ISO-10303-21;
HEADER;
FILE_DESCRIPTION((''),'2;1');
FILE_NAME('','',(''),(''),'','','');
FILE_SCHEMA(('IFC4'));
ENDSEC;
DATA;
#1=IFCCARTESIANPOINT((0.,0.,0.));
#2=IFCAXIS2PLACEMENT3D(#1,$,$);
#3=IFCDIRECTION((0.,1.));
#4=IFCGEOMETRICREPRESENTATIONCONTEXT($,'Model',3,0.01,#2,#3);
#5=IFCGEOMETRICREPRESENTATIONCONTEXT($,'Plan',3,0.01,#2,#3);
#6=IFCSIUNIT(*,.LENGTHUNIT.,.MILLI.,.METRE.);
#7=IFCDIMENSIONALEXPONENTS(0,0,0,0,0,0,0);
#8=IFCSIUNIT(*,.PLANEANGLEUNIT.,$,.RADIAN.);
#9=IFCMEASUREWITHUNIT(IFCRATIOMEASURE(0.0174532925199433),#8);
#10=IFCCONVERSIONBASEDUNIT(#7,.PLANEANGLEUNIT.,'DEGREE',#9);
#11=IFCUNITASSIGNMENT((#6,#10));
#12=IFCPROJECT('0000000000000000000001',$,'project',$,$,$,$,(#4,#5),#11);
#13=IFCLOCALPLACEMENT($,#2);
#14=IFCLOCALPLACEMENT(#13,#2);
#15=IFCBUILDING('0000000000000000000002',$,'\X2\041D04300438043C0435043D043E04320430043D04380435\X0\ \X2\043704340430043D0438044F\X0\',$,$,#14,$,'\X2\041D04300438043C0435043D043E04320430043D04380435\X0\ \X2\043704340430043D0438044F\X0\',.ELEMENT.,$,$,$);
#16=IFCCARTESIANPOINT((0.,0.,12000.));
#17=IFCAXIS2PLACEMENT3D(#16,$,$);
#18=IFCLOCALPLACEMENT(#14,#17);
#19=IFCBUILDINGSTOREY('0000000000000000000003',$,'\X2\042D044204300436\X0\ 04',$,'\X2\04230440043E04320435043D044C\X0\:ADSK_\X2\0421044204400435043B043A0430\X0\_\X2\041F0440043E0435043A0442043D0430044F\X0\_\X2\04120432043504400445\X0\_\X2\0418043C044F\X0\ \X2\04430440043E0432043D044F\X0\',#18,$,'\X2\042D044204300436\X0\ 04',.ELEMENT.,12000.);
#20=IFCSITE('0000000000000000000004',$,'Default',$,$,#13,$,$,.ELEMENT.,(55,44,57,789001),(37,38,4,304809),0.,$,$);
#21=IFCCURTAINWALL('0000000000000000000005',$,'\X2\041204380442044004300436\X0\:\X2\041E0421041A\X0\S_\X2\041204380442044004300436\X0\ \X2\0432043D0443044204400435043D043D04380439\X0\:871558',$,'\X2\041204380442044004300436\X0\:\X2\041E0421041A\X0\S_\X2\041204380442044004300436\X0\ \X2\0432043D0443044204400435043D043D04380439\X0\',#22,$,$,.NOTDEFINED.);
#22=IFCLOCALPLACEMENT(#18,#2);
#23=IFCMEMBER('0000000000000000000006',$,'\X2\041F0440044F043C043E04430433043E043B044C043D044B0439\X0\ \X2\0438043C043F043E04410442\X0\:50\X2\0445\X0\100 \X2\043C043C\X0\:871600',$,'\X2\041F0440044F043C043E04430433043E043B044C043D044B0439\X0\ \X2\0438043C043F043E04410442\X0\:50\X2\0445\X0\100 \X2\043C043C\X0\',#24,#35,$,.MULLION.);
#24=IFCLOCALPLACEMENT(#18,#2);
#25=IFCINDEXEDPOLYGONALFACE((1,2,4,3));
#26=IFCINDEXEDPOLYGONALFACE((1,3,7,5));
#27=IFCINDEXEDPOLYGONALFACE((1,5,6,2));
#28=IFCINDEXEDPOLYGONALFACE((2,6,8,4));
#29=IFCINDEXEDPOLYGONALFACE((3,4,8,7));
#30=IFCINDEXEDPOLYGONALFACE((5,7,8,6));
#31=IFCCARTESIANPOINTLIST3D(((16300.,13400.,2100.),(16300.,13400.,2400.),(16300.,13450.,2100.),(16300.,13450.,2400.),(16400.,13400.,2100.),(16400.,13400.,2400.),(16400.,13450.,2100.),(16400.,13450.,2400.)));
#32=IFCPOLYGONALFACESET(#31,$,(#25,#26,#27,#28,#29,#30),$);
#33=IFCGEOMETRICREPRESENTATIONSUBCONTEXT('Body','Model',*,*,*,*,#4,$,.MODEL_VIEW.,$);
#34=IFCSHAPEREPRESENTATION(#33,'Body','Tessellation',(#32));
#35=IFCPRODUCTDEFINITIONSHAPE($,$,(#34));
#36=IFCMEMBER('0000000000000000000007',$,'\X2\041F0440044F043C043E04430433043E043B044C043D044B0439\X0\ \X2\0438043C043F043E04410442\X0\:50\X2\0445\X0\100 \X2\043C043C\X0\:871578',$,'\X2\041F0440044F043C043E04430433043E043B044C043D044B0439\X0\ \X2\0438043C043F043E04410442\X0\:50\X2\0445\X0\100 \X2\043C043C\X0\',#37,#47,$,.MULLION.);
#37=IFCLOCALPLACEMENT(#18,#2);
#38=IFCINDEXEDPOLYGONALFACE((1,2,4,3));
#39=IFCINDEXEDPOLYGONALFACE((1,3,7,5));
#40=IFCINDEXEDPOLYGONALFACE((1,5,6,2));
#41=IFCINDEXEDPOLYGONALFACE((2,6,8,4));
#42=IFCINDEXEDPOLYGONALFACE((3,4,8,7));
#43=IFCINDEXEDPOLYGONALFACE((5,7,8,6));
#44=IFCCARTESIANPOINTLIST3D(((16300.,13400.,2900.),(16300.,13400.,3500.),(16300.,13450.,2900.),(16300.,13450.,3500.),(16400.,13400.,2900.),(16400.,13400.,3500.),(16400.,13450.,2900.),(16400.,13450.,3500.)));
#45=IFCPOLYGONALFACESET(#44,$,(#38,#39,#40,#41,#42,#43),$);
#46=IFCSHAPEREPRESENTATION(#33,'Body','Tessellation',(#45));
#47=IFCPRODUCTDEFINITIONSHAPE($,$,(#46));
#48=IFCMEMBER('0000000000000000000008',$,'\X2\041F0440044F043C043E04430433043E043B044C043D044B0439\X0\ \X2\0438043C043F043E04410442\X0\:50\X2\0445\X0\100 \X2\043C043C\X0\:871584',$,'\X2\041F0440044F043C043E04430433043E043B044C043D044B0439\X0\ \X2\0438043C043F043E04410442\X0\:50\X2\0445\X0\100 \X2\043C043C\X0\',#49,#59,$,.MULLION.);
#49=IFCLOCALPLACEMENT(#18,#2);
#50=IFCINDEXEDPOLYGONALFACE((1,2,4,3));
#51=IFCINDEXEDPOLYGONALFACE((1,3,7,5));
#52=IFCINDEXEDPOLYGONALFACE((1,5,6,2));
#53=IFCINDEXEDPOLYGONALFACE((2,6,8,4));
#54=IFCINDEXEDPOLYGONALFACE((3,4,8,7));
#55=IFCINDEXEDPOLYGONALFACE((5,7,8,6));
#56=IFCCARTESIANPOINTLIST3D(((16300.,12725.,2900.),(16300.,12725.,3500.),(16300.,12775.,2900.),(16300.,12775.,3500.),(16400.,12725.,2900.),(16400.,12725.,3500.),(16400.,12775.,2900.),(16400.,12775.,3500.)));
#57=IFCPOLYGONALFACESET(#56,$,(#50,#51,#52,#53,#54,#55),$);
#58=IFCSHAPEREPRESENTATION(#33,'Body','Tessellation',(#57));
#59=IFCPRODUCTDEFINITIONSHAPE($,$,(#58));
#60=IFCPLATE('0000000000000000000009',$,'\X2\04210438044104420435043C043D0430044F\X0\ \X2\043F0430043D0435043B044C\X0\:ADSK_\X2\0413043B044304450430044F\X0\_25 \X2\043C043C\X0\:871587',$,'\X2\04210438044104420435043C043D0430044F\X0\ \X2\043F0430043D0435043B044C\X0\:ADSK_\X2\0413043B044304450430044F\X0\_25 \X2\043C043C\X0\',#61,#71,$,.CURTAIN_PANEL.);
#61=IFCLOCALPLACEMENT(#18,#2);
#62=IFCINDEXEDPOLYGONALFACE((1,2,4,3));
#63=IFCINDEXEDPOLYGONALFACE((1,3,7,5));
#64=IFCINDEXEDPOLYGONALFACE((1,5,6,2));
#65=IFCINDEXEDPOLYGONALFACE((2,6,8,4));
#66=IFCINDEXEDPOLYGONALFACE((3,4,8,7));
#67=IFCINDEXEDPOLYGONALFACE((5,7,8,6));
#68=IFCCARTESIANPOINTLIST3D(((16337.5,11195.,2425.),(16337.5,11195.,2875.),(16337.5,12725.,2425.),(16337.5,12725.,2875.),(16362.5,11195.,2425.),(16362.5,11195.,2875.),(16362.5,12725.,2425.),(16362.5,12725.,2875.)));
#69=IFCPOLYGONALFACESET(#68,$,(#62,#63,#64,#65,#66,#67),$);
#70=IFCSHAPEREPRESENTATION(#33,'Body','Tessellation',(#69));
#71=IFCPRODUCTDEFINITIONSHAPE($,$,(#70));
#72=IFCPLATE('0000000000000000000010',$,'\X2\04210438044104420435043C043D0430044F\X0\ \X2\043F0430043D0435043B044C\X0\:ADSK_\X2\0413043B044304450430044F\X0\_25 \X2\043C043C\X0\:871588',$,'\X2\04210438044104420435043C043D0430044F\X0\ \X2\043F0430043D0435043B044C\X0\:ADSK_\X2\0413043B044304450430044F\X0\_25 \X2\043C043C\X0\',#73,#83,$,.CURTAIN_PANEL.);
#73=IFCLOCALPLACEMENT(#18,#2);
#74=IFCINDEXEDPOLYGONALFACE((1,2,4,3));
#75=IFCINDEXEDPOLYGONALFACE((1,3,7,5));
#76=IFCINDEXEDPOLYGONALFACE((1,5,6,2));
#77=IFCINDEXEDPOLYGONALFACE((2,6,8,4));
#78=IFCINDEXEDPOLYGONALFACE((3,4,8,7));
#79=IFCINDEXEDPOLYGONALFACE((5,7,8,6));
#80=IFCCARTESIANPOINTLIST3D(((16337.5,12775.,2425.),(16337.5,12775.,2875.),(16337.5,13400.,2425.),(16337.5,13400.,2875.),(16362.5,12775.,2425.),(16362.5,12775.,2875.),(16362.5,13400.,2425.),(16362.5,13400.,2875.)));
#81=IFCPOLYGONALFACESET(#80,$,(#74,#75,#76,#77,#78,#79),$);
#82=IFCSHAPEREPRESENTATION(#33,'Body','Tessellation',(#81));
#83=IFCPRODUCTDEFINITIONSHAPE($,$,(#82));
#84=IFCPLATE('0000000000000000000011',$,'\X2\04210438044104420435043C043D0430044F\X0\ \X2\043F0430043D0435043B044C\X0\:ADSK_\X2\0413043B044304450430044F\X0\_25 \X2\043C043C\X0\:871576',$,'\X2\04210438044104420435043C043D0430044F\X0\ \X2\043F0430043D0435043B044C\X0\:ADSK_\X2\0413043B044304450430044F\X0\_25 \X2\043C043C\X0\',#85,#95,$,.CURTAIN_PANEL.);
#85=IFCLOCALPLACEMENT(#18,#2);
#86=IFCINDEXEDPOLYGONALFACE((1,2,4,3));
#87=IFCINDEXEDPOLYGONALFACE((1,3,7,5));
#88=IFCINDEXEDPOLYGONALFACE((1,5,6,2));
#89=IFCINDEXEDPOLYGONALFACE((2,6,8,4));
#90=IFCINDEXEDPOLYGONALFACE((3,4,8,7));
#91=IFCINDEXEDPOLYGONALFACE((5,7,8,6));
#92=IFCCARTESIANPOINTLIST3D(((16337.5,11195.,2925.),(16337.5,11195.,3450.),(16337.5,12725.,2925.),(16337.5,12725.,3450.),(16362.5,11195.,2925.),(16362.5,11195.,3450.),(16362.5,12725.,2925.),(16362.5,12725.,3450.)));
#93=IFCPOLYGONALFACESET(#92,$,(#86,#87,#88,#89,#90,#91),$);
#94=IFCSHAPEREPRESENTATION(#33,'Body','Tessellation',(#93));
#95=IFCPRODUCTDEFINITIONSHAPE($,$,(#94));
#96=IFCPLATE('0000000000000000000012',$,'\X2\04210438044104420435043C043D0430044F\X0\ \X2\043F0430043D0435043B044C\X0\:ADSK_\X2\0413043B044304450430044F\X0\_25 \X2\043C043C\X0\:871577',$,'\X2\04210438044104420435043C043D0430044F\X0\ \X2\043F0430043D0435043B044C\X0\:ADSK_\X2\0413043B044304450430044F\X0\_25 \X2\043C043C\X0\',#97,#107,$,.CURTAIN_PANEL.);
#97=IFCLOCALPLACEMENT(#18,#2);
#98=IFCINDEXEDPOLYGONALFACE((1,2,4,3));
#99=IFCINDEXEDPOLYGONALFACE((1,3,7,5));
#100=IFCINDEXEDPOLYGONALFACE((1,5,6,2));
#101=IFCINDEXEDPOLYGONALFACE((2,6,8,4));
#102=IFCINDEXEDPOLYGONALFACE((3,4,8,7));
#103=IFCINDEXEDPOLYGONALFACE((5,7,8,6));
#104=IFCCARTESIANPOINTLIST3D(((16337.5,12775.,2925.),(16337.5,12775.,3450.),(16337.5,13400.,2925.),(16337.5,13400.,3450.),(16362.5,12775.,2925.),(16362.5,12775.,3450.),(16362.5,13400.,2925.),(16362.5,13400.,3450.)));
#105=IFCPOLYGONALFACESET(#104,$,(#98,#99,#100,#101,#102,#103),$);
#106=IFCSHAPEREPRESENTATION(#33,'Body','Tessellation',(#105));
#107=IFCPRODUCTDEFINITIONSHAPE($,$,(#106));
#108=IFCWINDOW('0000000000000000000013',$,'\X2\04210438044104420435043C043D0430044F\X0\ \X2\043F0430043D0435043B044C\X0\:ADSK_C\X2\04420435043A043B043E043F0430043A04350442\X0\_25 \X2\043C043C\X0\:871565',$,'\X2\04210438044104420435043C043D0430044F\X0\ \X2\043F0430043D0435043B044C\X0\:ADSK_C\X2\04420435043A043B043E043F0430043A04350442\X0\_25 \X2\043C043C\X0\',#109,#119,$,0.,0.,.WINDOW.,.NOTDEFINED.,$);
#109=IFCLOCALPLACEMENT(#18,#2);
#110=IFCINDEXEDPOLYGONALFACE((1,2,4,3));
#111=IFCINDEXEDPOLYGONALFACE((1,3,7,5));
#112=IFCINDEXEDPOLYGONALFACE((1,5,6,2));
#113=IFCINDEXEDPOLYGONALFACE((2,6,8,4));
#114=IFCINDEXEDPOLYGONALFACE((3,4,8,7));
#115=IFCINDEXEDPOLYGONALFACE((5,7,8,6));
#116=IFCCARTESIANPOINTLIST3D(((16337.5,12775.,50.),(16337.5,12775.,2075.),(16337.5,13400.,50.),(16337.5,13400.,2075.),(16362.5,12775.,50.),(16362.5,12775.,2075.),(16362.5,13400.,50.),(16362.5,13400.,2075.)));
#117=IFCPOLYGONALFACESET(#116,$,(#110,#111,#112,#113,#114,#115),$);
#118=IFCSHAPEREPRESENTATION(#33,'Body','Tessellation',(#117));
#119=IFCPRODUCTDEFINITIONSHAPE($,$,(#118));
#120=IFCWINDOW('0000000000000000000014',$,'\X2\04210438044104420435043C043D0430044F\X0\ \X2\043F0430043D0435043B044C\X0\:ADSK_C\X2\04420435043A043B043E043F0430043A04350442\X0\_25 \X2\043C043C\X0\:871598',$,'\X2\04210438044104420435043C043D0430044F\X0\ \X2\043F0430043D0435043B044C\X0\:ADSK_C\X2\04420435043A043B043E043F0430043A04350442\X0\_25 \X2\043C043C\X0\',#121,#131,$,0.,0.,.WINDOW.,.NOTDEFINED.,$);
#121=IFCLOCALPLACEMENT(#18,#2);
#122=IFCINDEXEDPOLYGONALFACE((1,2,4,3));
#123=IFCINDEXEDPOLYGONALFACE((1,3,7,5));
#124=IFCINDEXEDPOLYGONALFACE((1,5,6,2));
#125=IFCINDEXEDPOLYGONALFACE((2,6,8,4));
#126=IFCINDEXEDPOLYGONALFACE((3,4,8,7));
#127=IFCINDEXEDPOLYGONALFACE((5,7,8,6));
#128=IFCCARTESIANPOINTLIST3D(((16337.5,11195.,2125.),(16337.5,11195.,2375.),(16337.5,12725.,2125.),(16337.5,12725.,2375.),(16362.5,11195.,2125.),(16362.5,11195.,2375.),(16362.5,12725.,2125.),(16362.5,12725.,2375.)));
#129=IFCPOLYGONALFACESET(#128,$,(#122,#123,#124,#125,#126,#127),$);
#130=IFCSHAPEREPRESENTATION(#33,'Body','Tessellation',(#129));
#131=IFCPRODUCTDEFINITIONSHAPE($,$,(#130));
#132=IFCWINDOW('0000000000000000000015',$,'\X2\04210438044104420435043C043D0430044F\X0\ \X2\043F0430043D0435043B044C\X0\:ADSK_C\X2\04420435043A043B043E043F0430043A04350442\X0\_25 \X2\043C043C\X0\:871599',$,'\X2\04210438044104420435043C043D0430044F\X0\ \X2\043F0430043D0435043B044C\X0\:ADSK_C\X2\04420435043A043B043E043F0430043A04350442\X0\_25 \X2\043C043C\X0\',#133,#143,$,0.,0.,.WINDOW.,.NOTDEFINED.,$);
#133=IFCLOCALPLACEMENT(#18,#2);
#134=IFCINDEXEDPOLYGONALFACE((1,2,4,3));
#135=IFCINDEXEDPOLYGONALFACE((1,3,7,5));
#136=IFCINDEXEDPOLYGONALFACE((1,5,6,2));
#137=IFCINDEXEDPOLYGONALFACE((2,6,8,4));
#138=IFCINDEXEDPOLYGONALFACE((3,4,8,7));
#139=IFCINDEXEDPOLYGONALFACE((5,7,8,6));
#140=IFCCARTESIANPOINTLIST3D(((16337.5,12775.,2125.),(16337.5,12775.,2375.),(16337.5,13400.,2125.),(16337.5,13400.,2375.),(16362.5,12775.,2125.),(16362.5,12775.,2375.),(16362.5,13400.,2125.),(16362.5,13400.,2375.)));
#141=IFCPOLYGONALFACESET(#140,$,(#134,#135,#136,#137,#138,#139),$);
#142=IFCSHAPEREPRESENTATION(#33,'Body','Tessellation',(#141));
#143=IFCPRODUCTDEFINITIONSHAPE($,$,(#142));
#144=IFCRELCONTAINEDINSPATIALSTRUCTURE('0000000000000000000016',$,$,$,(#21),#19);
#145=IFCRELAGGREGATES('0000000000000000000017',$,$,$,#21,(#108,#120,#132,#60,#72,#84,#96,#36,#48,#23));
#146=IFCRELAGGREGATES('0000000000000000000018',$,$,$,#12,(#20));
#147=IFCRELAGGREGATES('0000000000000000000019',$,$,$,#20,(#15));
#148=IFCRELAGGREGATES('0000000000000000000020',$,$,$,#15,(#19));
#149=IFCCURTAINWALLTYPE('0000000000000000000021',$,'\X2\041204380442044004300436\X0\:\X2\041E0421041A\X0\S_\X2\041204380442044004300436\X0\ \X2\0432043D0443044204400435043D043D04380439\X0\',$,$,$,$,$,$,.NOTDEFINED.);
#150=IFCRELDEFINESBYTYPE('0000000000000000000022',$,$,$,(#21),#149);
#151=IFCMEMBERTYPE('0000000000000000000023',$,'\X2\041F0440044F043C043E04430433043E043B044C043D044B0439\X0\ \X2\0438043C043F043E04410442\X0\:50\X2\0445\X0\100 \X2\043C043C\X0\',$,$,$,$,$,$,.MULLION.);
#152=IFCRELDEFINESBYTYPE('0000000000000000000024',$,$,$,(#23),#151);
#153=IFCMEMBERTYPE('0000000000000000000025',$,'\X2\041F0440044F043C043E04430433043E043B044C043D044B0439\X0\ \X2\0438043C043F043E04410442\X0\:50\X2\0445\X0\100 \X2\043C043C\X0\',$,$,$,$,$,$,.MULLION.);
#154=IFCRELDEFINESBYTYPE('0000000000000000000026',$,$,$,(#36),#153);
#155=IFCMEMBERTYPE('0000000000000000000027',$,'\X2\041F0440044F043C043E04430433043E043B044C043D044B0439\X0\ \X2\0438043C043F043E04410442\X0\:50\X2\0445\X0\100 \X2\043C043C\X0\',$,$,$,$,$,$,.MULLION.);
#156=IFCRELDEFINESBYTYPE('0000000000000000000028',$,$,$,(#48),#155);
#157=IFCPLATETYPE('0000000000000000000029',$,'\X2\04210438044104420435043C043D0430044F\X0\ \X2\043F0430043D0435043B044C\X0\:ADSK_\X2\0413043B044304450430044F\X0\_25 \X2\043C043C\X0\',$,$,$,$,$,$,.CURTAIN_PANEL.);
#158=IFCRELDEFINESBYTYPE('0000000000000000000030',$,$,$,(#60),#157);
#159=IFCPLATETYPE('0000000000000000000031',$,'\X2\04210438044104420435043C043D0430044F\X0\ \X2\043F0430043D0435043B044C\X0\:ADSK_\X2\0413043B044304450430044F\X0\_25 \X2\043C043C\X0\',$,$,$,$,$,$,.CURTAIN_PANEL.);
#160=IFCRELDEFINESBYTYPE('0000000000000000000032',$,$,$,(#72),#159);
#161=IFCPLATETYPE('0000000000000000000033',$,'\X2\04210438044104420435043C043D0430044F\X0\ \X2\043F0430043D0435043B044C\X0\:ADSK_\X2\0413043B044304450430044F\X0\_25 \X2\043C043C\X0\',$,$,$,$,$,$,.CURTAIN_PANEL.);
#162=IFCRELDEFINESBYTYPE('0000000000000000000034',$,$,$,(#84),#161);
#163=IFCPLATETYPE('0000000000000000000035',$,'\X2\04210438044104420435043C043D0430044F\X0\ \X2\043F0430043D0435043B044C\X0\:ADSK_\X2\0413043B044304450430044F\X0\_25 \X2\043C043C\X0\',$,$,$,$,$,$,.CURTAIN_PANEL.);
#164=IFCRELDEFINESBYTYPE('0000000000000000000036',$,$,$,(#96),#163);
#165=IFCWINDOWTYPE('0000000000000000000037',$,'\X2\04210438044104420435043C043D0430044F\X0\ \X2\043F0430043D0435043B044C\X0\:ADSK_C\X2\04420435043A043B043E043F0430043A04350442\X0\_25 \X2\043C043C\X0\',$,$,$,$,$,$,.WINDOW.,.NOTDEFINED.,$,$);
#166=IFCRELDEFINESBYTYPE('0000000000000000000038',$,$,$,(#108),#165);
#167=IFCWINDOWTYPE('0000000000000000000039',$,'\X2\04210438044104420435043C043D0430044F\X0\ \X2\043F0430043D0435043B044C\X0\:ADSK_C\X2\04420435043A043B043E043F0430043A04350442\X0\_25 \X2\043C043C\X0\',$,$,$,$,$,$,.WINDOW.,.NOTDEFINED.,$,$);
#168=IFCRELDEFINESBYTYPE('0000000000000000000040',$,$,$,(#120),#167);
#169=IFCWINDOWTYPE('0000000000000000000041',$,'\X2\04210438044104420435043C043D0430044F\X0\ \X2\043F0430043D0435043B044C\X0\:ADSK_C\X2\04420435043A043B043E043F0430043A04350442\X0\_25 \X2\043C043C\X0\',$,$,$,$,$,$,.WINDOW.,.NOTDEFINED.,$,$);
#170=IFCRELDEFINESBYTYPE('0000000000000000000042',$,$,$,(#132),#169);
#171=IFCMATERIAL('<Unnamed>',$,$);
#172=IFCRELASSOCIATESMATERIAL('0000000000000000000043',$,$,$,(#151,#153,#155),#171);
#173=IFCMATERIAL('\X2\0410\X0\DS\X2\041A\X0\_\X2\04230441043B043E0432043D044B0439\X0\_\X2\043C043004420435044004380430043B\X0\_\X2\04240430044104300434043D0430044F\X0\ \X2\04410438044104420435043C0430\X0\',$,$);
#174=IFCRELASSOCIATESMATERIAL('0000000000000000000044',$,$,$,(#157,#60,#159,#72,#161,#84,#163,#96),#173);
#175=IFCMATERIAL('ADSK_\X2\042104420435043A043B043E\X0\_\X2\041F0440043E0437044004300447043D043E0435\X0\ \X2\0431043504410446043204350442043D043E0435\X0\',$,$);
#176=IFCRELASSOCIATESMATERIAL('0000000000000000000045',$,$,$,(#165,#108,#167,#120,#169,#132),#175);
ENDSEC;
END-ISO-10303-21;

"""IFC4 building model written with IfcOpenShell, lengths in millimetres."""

from ifc_helpers import new_model, entity, si_unit, converted_unit, direction, frame, origin, place, context, subcontext, project, spatial, indexed_curve, outline, extrude, source, transform, mapped, material, type_object, type_shapes, element, aggregate, save


model = new_model("IFC4")

# Units and contexts
model_context = context("Model", 3, precision=0.01, world=origin(), true_north=direction((0.0, 1.0)))
plan_context = context("Plan", 3, precision=0.01, world=origin(), true_north=direction((0.0, 1.0)))
body_context = subcontext(model_context, "Body", "Model", "MODEL_VIEW")
ifc_project = project(units=[si_unit("LENGTHUNIT", "METRE", prefix="MILLI"), converted_unit("PLANEANGLEUNIT", "DEGREE", entity("IfcRatioMeasure", 0.0174532925199433), si_unit("PLANEANGLEUNIT", "RADIAN"), dimensions=[0, 0, 0, 0, 0, 0, 0])], contexts=[model_context, plan_context])

# Site, building, storey
site_placement = place(None, frame((0.0, 0.0, 0.0)))
site = spatial("IfcSite", under=ifc_project, at=site_placement, Name="Default", CompositionType="ELEMENT", RefLatitude=(55, 44, 57, 789001), RefLongitude=(37, 38, 4, 304809), RefElevation=0.0)
building_placement = place(site_placement, origin())
building = spatial("IfcBuilding", under=site, at=building_placement, Name="Наименование здания", LongName="Наименование здания", CompositionType="ELEMENT")
storey_placement = place(building_placement, frame((0.0, 0.0, 12000.0)))
storey = spatial("IfcBuildingStorey", under=building, at=storey_placement, Name="Этаж 04", ObjectType="Уровень:ADSK_Стрелка_Проектная_Вверх_Имя уровня", LongName="Этаж 04", CompositionType="ELEMENT", Elevation=12000.0)

# Curtain wall, members, plates
curtain_wall_type = type_object("IfcCurtainWallType", Name="Витраж:ОСКS_Витраж внутренний", PredefinedType="NOTDEFINED")
curtain_wall_placement = place(storey_placement, frame((0.0, 0.0, -12000.0)))
curtain_wall = element("IfcCurtainWall", 1, at=curtain_wall_placement, inside=storey, type_object=curtain_wall_type, Name="Витраж:ОСКS_Витраж внутренний:871558", ObjectType="Витраж:ОСКS_Витраж внутренний", PredefinedType="NOTDEFINED")
ifc_material_1 = material(Name="<Unnamed>")
member_type_1 = type_object("IfcMemberType", Name="Прямоугольный импост:50х100 мм", PredefinedType="MULLION", material=ifc_material_1)
shared_shape_1 = source(origin(), body_context, "Body", "SweptSolid", [
    extrude(outline(indexed_curve([(-50.0, -25.0), (50.0, -25.0), (50.0, 25.0), (-50.0, 25.0), (-50.0, -25.0)], self_intersect=False)), frame((-25.0, 0.0, -300.0), z_axis=(0.0, 0.0, 1.0), x_axis=(0.0, -1.0, 0.0)), (0.0, 0.0, 1.0), 300.0),
])
type_shapes(member_type_1, [shared_shape_1])
member_1_placement = place(storey_placement, frame((16350.0, 13450.0, 2100.0), z_axis=(0.0, 0.0, -1.0), x_axis=(0.0, 1.0, 0.0)))
member_1 = element("IfcMember", 2, at=member_1_placement, type_object=member_type_1, Name="Прямоугольный импост:50х100 мм:871600", ObjectType="Прямоугольный импост:50х100 мм", PredefinedType="MULLION", context=body_context, shape_type="MappedRepresentation", body=[
    mapped(shared_shape_1, transform((0.0, 0.0, 0.0), scale=1.0)),
])
member_type_2 = type_object("IfcMemberType", Name="Прямоугольный импост:50х100 мм", PredefinedType="MULLION", material=ifc_material_1)
shared_shape_2 = source(origin(), body_context, "Body", "SweptSolid", [
    extrude(outline(indexed_curve([(-50.0, -25.0), (50.0, -25.0), (50.0, 25.0), (-50.0, 25.0), (-50.0, -25.0)], self_intersect=False)), frame((-25.0, 0.0, -600.0), z_axis=(0.0, 0.0, 1.0), x_axis=(0.0, -1.0, 0.0)), (0.0, 0.0, 1.0), 600.0),
])
type_shapes(member_type_2, [shared_shape_2])
member_2_placement = place(storey_placement, frame((16350.0, 13450.0, 2900.0), z_axis=(0.0, 0.0, -1.0), x_axis=(0.0, 1.0, 0.0)))
member_2 = element("IfcMember", 3, at=member_2_placement, type_object=member_type_2, Name="Прямоугольный импост:50х100 мм:871578", ObjectType="Прямоугольный импост:50х100 мм", PredefinedType="MULLION", context=body_context, shape_type="MappedRepresentation", body=[
    mapped(shared_shape_2, transform((0.0, 0.0, 0.0), scale=1.0)),
])
member_type_3 = type_object("IfcMemberType", Name="Прямоугольный импост:50х100 мм", PredefinedType="MULLION", material=ifc_material_1)
shared_shape_3 = source(origin(), body_context, "Body", "SweptSolid", [
    extrude(outline(indexed_curve([(-50.0, -25.0), (50.0, -25.0), (50.0, 25.0), (-50.0, 25.0), (-50.0, -25.0)], self_intersect=False)), frame((0.0, 0.0, -600.0), z_axis=(0.0, 0.0, 1.0), x_axis=(0.0, -1.0, 0.0)), (0.0, 0.0, 1.0), 600.0),
])
type_shapes(member_type_3, [shared_shape_3])
member_3_placement = place(storey_placement, frame((16350.0, 12750.0, 2900.0), z_axis=(0.0, 0.0, -1.0), x_axis=(0.0, 1.0, 0.0)))
member_3 = element("IfcMember", 4, at=member_3_placement, type_object=member_type_3, Name="Прямоугольный импост:50х100 мм:871584", ObjectType="Прямоугольный импост:50х100 мм", PredefinedType="MULLION", context=body_context, shape_type="MappedRepresentation", body=[
    mapped(shared_shape_3, transform((0.0, 0.0, 0.0), scale=1.0)),
])
ifc_material_2 = material(Name="АDSК_Условный_материал_Фасадная система")
plate_type_1 = type_object("IfcPlateType", Name="Системная панель:ADSK_Глухая_25 мм", PredefinedType="CURTAIN_PANEL", material=ifc_material_2)
shared_shape_4 = source(origin(), body_context, "Body", "SweptSolid", [
    extrude(outline(indexed_curve([(-12.5, -765.0), (12.5, -765.0), (12.5, 765.0), (-12.5, 765.0), (-12.5, -765.0)], self_intersect=False)), frame((0.0, 0.0, 0.0), z_axis=(0.0, 0.0, 1.0), x_axis=(0.0, 1.0, 0.0)), (0.0, 0.0, 1.0), 450.0),
])
type_shapes(plate_type_1, [shared_shape_4])
plate_1_placement = place(curtain_wall_placement, frame((16350.0, 11960.0, 14425.0), z_axis=(0.0, 0.0, 1.0), x_axis=(0.0, 1.0, 0.0)))
plate_1 = element("IfcPlate", 5, at=plate_1_placement, type_object=plate_type_1, material=ifc_material_2, Name="Системная панель:ADSK_Глухая_25 мм:871587", ObjectType="Системная панель:ADSK_Глухая_25 мм", PredefinedType="CURTAIN_PANEL", context=body_context, shape_type="MappedRepresentation", body=[
    mapped(shared_shape_4, transform((0.0, 0.0, 0.0), scale=1.0)),
])
plate_type_2 = type_object("IfcPlateType", Name="Системная панель:ADSK_Глухая_25 мм", PredefinedType="CURTAIN_PANEL", material=ifc_material_2)
shared_shape_5 = source(origin(), body_context, "Body", "SweptSolid", [
    extrude(outline(indexed_curve([(-12.5, -312.5), (12.5, -312.5), (12.5, 312.5), (-12.5, 312.5), (-12.5, -312.5)], self_intersect=False)), frame((0.0, 0.0, 0.0), z_axis=(0.0, 0.0, 1.0), x_axis=(0.0, 1.0, 0.0)), (0.0, 0.0, 1.0), 450.0),
])
type_shapes(plate_type_2, [shared_shape_5])
plate_2_placement = place(curtain_wall_placement, frame((16350.0, 13087.5, 14425.0), z_axis=(0.0, 0.0, 1.0), x_axis=(0.0, 1.0, 0.0)))
plate_2 = element("IfcPlate", 6, at=plate_2_placement, type_object=plate_type_2, material=ifc_material_2, Name="Системная панель:ADSK_Глухая_25 мм:871588", ObjectType="Системная панель:ADSK_Глухая_25 мм", PredefinedType="CURTAIN_PANEL", context=body_context, shape_type="MappedRepresentation", body=[
    mapped(shared_shape_5, transform((0.0, 0.0, 0.0), scale=1.0)),
])
plate_type_3 = type_object("IfcPlateType", Name="Системная панель:ADSK_Глухая_25 мм", PredefinedType="CURTAIN_PANEL", material=ifc_material_2)
shared_shape_6 = source(origin(), body_context, "Body", "SweptSolid", [
    extrude(outline(indexed_curve([(-12.5, -765.0), (12.5, -765.0), (12.5, 765.0), (-12.5, 765.0), (-12.5, -765.0)], self_intersect=False)), frame((0.0, 0.0, 0.0), z_axis=(0.0, 0.0, 1.0), x_axis=(0.0, 1.0, 0.0)), (0.0, 0.0, 1.0), 525.0),
])
type_shapes(plate_type_3, [shared_shape_6])
plate_3_placement = place(curtain_wall_placement, frame((16350.0, 11960.0, 14925.0), z_axis=(0.0, 0.0, 1.0), x_axis=(0.0, 1.0, 0.0)))
plate_3 = element("IfcPlate", 7, at=plate_3_placement, type_object=plate_type_3, material=ifc_material_2, Name="Системная панель:ADSK_Глухая_25 мм:871576", ObjectType="Системная панель:ADSK_Глухая_25 мм", PredefinedType="CURTAIN_PANEL", context=body_context, shape_type="MappedRepresentation", body=[
    mapped(shared_shape_6, transform((0.0, 0.0, 0.0), scale=1.0)),
])
plate_type_4 = type_object("IfcPlateType", Name="Системная панель:ADSK_Глухая_25 мм", PredefinedType="CURTAIN_PANEL", material=ifc_material_2)
shared_shape_7 = source(origin(), body_context, "Body", "SweptSolid", [
    extrude(outline(indexed_curve([(-12.5, -312.5), (12.5, -312.5), (12.5, 312.5), (-12.5, 312.5), (-12.5, -312.5)], self_intersect=False)), frame((0.0, 0.0, 0.0), z_axis=(0.0, 0.0, 1.0), x_axis=(0.0, 1.0, 0.0)), (0.0, 0.0, 1.0), 525.0),
])
type_shapes(plate_type_4, [shared_shape_7])
plate_4_placement = place(curtain_wall_placement, frame((16350.0, 13087.5, 14925.0), z_axis=(0.0, 0.0, 1.0), x_axis=(0.0, 1.0, 0.0)))
plate_4 = element("IfcPlate", 8, at=plate_4_placement, type_object=plate_type_4, material=ifc_material_2, Name="Системная панель:ADSK_Глухая_25 мм:871577", ObjectType="Системная панель:ADSK_Глухая_25 мм", PredefinedType="CURTAIN_PANEL", context=body_context, shape_type="MappedRepresentation", body=[
    mapped(shared_shape_7, transform((0.0, 0.0, 0.0), scale=1.0)),
])

# Windows
ifc_material_3 = material(Name="ADSK_Стекло_Прозрачное бесцветное")
window_type_1 = type_object("IfcWindowType", Name="Системная панель:ADSK_Cтеклопакет_25 мм", PartitioningType="NOTDEFINED", PredefinedType="WINDOW", material=ifc_material_3)
shared_shape_8 = source(origin(), body_context, "Body", "SweptSolid", [
    extrude(outline(indexed_curve([(-12.5, -312.5), (12.5, -312.5), (12.5, 312.5), (-12.5, 312.5), (-12.5, -312.5)], self_intersect=False)), frame((0.0, 0.0, 0.0), z_axis=(0.0, 0.0, 1.0), x_axis=(0.0, 1.0, 0.0)), (0.0, 0.0, 1.0), 2025.0),
])
type_shapes(window_type_1, [shared_shape_8])
window_1_placement = place(curtain_wall_placement, frame((16350.0, 13087.5, 12050.0), z_axis=(0.0, 0.0, 1.0), x_axis=(0.0, 1.0, 0.0)))
window_1 = element("IfcWindow", 9, at=window_1_placement, type_object=window_type_1, material=ifc_material_3, Name="Системная панель:ADSK_Cтеклопакет_25 мм:871565", ObjectType="Системная панель:ADSK_Cтеклопакет_25 мм", OverallHeight=0.0, OverallWidth=0.0, PartitioningType="NOTDEFINED", PredefinedType="WINDOW", context=body_context, shape_type="MappedRepresentation", body=[
    mapped(shared_shape_8, transform((0.0, 0.0, 0.0), scale=1.0)),
])
window_type_2 = type_object("IfcWindowType", Name="Системная панель:ADSK_Cтеклопакет_25 мм", PartitioningType="NOTDEFINED", PredefinedType="WINDOW", material=ifc_material_3)
shared_shape_9 = source(origin(), body_context, "Body", "SweptSolid", [
    extrude(outline(indexed_curve([(-12.5, -765.0), (12.5, -765.0), (12.5, 765.0), (-12.5, 765.0), (-12.5, -765.0)], self_intersect=False)), frame((0.0, 0.0, 0.0), z_axis=(0.0, 0.0, 1.0), x_axis=(0.0, 1.0, 0.0)), (0.0, 0.0, 1.0), 250.0),
])
type_shapes(window_type_2, [shared_shape_9])
window_2_placement = place(curtain_wall_placement, frame((16350.0, 11960.0, 14125.0), z_axis=(0.0, 0.0, 1.0), x_axis=(0.0, 1.0, 0.0)))
window_2 = element("IfcWindow", 10, at=window_2_placement, type_object=window_type_2, material=ifc_material_3, Name="Системная панель:ADSK_Cтеклопакет_25 мм:871598", ObjectType="Системная панель:ADSK_Cтеклопакет_25 мм", OverallHeight=0.0, OverallWidth=0.0, PartitioningType="NOTDEFINED", PredefinedType="WINDOW", context=body_context, shape_type="MappedRepresentation", body=[
    mapped(shared_shape_9, transform((0.0, 0.0, 0.0), scale=1.0)),
])
window_type_3 = type_object("IfcWindowType", Name="Системная панель:ADSK_Cтеклопакет_25 мм", PartitioningType="NOTDEFINED", PredefinedType="WINDOW", material=ifc_material_3)
shared_shape_10 = source(origin(), body_context, "Body", "SweptSolid", [
    extrude(outline(indexed_curve([(-12.5, -312.5), (12.5, -312.5), (12.5, 312.5), (-12.5, 312.5), (-12.5, -312.5)], self_intersect=False)), frame((0.0, 0.0, 0.0), z_axis=(0.0, 0.0, 1.0), x_axis=(0.0, 1.0, 0.0)), (0.0, 0.0, 1.0), 250.0),
])
type_shapes(window_type_3, [shared_shape_10])
window_3_placement = place(curtain_wall_placement, frame((16350.0, 13087.5, 14125.0), z_axis=(0.0, 0.0, 1.0), x_axis=(0.0, 1.0, 0.0)))
window_3 = element("IfcWindow", 11, at=window_3_placement, type_object=window_type_3, material=ifc_material_3, Name="Системная панель:ADSK_Cтеклопакет_25 мм:871599", ObjectType="Системная панель:ADSK_Cтеклопакет_25 мм", OverallHeight=0.0, OverallWidth=0.0, PartitioningType="NOTDEFINED", PredefinedType="WINDOW", context=body_context, shape_type="MappedRepresentation", body=[
    mapped(shared_shape_10, transform((0.0, 0.0, 0.0), scale=1.0)),
])
aggregate(curtain_wall, [window_1, window_2, window_3, plate_1, plate_2, plate_3, plate_4, member_2, member_3, member_1])

save(model, "model.ifc")
